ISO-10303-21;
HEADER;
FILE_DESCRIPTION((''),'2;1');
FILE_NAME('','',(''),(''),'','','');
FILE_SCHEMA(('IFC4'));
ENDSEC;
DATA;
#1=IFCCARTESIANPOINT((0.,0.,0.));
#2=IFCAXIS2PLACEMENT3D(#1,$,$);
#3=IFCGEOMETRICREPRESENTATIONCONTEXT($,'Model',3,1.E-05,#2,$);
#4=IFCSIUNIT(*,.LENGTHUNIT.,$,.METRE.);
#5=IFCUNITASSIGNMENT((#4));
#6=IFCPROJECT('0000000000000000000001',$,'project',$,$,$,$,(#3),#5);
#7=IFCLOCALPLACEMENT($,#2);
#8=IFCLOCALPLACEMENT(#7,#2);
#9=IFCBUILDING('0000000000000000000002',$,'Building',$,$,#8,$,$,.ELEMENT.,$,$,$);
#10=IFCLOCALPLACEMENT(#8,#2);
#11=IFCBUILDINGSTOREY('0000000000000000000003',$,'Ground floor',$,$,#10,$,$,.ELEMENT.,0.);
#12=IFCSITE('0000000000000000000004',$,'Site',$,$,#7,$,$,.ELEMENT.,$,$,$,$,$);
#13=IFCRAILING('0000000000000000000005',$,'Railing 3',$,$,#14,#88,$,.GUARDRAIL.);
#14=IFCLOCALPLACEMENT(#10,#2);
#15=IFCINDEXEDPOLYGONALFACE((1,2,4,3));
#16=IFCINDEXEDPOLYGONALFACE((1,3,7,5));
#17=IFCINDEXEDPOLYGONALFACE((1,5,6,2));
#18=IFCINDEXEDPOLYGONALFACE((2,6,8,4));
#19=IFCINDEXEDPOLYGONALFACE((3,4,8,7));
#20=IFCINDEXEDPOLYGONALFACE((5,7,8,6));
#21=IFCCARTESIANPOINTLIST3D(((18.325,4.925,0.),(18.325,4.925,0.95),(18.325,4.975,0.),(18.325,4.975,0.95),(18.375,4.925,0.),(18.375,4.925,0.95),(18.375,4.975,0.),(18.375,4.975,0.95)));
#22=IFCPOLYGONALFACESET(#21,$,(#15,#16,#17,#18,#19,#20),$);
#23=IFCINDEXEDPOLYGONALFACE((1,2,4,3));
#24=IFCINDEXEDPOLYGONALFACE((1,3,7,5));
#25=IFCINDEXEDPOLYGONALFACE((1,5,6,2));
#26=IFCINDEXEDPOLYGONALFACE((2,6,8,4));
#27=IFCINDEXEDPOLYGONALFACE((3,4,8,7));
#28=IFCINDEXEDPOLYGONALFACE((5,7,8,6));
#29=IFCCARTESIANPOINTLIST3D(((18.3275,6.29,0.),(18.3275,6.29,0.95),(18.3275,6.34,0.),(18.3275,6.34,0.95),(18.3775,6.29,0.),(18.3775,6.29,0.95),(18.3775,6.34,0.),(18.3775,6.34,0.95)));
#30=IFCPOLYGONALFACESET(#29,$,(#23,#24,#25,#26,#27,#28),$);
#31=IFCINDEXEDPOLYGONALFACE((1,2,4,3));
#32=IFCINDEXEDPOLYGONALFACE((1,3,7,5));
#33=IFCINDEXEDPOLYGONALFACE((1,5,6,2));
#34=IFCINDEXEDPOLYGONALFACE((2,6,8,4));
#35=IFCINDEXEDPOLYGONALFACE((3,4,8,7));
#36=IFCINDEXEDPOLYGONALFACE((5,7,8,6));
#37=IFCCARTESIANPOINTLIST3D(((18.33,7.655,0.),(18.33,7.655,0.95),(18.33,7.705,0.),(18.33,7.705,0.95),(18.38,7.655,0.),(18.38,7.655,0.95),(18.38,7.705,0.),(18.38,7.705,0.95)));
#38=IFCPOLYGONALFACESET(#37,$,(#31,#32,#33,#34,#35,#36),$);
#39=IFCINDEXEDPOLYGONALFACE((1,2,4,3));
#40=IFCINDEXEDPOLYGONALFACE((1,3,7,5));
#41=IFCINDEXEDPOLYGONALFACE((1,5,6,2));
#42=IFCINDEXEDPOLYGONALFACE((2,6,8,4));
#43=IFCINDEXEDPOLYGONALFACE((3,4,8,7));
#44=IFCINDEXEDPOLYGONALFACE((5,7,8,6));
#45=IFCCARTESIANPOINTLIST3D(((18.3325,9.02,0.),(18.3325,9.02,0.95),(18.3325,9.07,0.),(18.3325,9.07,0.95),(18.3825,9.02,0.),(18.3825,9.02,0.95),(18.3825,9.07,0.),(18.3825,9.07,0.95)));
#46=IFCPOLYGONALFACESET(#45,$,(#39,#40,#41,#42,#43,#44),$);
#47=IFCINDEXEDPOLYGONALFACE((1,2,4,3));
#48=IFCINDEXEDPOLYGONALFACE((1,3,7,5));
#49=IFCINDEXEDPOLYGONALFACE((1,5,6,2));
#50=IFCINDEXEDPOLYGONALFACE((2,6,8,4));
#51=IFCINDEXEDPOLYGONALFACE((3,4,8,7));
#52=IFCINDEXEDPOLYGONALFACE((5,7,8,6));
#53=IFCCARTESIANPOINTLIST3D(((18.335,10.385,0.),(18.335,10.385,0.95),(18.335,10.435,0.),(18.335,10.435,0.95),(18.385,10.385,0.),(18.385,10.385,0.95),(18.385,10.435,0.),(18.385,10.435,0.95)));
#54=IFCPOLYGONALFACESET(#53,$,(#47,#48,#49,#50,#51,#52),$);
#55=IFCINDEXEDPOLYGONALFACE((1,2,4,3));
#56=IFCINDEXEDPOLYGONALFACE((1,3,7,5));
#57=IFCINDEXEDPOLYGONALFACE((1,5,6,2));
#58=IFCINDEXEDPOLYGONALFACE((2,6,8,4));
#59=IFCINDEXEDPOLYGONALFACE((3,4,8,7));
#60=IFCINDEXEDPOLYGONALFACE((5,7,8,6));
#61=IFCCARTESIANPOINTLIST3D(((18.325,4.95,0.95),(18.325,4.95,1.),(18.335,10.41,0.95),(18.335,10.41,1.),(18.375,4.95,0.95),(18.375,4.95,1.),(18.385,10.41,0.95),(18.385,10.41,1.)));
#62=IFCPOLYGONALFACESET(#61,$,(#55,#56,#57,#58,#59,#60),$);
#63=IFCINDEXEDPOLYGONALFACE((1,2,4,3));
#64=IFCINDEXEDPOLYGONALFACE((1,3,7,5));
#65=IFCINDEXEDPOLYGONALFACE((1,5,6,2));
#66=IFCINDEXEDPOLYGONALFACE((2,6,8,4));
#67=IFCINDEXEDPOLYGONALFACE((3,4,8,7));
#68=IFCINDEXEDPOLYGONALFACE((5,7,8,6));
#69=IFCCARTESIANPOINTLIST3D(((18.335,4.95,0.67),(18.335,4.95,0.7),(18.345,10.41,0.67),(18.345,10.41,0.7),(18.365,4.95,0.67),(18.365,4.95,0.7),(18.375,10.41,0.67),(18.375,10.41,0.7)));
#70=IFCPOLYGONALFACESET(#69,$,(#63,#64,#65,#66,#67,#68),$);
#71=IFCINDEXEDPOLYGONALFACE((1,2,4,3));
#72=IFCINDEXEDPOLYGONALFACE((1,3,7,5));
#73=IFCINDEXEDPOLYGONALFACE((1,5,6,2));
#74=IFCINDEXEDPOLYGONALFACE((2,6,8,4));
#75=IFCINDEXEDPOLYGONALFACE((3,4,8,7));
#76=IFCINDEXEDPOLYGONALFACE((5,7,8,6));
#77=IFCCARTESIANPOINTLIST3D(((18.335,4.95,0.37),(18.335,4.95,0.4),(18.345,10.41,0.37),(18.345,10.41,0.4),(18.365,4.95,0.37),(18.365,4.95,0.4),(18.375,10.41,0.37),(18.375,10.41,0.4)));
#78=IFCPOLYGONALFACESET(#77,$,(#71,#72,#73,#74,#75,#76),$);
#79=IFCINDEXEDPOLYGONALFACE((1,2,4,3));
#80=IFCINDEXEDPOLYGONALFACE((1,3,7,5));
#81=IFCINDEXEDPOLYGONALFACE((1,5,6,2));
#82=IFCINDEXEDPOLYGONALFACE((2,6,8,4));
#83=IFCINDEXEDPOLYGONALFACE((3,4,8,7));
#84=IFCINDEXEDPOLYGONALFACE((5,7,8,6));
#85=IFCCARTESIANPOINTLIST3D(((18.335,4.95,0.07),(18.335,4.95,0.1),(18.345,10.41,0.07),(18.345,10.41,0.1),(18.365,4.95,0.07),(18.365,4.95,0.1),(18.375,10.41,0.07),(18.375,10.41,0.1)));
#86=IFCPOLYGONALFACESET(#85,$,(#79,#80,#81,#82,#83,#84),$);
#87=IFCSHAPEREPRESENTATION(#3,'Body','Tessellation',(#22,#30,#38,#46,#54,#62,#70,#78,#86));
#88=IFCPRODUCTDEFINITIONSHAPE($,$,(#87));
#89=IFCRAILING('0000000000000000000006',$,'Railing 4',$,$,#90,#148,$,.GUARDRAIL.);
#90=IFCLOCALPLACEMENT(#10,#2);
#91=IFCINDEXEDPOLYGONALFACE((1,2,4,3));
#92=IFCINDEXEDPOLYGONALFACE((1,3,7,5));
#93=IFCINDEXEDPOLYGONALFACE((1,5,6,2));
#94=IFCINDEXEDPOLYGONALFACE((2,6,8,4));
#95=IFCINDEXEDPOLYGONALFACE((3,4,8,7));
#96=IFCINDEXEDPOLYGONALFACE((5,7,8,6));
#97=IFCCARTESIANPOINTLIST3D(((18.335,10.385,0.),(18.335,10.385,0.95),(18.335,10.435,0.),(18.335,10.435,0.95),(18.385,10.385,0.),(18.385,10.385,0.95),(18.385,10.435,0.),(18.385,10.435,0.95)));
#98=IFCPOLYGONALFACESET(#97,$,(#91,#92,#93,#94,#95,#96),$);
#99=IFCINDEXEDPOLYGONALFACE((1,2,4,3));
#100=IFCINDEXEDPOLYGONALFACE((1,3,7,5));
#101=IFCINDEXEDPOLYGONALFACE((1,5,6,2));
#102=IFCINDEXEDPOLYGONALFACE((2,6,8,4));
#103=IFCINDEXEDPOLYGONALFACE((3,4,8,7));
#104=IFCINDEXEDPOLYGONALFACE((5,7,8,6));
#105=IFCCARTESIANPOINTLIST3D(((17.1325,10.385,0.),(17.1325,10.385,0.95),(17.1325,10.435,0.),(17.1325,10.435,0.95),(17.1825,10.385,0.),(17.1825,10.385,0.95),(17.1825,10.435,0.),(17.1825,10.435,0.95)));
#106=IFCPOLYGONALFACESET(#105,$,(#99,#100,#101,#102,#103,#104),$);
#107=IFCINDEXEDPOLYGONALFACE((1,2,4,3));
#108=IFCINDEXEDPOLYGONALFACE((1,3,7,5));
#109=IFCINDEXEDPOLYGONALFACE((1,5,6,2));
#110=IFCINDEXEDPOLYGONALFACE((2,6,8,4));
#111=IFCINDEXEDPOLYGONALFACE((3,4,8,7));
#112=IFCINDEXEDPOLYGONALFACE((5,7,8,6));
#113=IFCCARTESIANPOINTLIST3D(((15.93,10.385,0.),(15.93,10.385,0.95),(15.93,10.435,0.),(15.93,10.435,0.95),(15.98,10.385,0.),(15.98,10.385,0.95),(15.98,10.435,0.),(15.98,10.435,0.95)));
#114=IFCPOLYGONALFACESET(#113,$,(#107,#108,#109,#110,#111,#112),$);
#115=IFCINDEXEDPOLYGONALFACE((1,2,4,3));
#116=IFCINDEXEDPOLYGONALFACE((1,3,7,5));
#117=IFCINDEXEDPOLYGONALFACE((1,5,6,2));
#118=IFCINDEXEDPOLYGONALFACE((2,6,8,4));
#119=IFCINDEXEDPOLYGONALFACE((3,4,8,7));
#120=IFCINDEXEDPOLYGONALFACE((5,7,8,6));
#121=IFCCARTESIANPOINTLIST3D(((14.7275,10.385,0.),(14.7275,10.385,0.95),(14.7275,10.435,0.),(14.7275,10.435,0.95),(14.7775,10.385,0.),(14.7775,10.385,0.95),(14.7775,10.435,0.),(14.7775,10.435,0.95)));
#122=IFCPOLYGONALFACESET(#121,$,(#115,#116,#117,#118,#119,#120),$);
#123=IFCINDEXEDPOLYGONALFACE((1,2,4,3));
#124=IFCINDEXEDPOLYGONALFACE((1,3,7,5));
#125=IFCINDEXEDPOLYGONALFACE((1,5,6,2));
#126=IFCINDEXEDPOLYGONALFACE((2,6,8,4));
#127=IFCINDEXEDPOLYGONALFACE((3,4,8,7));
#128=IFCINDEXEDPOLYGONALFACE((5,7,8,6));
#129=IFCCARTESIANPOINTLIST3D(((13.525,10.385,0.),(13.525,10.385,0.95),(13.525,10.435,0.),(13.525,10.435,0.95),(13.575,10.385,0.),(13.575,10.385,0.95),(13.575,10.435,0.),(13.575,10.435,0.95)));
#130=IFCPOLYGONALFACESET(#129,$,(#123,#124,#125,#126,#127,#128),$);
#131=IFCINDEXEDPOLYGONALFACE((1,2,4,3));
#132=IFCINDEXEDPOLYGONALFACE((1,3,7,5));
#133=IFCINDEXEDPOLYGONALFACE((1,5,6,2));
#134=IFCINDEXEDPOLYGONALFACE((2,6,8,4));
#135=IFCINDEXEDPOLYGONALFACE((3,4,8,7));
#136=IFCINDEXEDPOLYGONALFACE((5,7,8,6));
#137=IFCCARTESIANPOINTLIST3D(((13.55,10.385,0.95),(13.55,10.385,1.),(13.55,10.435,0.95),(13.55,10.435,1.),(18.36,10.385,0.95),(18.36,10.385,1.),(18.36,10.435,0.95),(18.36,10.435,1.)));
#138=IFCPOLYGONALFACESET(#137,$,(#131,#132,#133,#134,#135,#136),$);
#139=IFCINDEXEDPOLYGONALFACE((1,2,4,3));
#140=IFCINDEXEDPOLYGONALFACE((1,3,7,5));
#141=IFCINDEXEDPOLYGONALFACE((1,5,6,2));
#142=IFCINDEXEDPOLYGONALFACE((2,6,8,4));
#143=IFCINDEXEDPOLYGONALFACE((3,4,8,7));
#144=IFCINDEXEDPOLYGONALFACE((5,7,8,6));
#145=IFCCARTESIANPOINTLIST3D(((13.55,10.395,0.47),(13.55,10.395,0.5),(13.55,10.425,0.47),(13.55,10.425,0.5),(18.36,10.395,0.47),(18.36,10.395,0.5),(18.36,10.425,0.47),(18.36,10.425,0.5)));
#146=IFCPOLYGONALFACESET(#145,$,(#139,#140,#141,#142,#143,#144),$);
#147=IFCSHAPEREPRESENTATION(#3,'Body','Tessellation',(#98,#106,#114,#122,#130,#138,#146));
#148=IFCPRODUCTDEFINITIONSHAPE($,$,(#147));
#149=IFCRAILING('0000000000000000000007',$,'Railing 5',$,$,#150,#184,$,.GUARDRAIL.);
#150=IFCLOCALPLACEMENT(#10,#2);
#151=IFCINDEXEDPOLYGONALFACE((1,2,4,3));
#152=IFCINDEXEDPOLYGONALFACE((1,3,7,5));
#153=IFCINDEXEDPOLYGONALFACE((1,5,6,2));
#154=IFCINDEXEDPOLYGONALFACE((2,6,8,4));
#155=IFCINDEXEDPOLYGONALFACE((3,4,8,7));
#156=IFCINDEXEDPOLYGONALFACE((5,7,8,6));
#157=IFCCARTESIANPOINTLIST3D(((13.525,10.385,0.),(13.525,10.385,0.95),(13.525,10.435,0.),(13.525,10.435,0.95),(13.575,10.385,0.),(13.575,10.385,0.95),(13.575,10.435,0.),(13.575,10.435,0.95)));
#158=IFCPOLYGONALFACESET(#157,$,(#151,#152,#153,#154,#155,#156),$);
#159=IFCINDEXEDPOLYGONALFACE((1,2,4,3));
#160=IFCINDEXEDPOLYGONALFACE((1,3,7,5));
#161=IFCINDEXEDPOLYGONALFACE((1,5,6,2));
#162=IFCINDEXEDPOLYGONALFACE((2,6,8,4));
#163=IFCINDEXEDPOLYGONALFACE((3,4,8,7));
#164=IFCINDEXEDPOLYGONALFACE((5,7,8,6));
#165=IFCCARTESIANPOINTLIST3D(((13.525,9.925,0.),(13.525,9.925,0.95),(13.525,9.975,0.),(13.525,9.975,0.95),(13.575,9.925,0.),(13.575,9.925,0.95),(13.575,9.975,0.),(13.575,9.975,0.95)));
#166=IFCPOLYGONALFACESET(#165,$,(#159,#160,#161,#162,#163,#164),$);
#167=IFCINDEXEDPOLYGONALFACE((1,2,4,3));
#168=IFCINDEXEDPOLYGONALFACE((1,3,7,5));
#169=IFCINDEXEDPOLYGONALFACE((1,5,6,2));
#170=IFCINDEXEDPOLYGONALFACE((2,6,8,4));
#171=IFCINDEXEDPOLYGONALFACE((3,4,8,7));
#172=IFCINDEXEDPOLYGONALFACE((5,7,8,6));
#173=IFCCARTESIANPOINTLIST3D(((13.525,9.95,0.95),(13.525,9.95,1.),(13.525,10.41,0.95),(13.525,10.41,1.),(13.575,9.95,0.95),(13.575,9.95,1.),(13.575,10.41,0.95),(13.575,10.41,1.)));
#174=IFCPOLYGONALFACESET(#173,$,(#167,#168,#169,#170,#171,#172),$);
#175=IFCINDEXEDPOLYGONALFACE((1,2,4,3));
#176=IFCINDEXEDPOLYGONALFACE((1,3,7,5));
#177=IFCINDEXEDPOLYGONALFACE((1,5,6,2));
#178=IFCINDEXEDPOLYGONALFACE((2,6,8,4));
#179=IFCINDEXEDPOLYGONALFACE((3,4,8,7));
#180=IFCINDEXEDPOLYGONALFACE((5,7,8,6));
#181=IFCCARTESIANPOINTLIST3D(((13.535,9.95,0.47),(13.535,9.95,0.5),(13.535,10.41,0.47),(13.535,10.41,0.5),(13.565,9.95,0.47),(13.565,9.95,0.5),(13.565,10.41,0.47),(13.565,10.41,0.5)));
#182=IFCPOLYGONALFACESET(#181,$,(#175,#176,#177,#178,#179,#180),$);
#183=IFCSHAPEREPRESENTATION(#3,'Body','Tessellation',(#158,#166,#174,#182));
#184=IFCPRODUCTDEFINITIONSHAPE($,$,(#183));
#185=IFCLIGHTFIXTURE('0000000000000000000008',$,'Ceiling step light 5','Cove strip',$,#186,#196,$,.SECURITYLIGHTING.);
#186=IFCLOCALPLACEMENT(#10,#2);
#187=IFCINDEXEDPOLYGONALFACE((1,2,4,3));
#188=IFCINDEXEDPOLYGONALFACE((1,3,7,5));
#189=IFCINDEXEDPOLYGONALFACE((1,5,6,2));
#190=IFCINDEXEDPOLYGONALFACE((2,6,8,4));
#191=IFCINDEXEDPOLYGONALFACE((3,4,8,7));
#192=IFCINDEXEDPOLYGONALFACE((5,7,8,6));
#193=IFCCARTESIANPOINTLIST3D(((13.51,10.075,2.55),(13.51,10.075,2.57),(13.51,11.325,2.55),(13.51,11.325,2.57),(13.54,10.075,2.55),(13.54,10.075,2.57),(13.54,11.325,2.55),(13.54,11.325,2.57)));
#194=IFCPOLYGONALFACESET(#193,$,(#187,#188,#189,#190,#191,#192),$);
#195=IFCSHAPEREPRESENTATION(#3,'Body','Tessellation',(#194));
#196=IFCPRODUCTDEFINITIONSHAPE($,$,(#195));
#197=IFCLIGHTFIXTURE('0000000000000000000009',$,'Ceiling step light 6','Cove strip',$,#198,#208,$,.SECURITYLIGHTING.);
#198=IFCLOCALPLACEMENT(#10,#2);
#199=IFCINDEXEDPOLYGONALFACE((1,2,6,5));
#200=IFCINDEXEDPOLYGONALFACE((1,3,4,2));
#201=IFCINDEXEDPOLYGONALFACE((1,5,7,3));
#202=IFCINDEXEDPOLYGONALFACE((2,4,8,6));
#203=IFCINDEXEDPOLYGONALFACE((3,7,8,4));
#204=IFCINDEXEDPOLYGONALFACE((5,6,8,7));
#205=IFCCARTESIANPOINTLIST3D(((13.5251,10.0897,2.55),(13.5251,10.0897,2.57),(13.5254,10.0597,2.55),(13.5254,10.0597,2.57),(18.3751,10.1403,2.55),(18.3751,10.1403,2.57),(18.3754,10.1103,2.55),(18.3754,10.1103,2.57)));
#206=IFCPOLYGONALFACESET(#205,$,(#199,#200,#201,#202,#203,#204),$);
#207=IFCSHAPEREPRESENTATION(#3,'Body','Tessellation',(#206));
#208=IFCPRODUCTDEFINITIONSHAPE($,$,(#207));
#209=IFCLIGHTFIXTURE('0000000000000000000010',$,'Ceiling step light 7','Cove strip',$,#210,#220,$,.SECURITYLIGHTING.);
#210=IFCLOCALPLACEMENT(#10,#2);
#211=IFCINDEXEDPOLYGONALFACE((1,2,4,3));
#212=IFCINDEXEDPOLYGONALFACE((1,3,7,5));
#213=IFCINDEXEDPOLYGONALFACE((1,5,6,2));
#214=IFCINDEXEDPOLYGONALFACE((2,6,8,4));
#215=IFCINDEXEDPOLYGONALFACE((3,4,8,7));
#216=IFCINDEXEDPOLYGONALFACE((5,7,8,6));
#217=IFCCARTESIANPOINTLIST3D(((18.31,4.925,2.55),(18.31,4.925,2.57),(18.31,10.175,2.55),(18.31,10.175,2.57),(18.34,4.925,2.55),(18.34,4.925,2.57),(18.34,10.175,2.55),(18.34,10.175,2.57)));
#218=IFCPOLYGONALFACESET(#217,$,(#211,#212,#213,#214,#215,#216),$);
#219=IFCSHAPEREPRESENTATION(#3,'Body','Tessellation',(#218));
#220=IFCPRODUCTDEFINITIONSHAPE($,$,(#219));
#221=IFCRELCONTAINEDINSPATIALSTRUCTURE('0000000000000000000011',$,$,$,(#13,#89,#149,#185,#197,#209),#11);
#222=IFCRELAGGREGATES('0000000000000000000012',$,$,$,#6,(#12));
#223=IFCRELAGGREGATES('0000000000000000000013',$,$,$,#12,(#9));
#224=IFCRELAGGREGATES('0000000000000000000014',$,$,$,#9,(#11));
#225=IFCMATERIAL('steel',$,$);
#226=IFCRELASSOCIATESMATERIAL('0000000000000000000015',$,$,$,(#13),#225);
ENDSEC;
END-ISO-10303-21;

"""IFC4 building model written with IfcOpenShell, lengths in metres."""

from ifc_helpers import new_model, si_unit, frame, frame_2d, origin, origin_2d, place, context, project, spatial, polyline, rectangle, outline, extrude, material, element, save


model = new_model("IFC4")

# Units and contexts
model_context = context("Model", 3, precision=1e-05, world=origin())
ifc_project = project(units=[si_unit("LENGTHUNIT", "METRE")], contexts=[model_context])

# Site, building, storey
site_placement = place(None, origin())
site = spatial("IfcSite", under=ifc_project, at=site_placement, Name="Site", CompositionType="ELEMENT")
building_placement = place(site_placement, origin())
building = spatial("IfcBuilding", under=site, at=building_placement, Name="Building", CompositionType="ELEMENT")
storey_placement = place(building_placement, origin())
storey = spatial("IfcBuildingStorey", under=building, at=storey_placement, Name="Ground floor", CompositionType="ELEMENT", Elevation=0.0)

# Railings
ifc_material = material(Name="steel")
railing_1_placement = place(storey_placement, frame((18.35, 4.95, 0.0), z_axis=(0.0, 0.0, 1.0), x_axis=(0.001831, 0.999998, 0.0)))
element("IfcRailing", 1, at=railing_1_placement, inside=storey, material=ifc_material, Name="Railing 3", PredefinedType="GUARDRAIL", context=model_context, shape_type="SweptSolid", body=[
    extrude(rectangle(XDim=0.05, YDim=0.05, at=origin_2d()), origin(), (0.0, 0.0, 1.0), 0.95),
    extrude(rectangle(XDim=0.05, YDim=0.05, at=frame_2d((1.365, 0.0))), origin(), (0.0, 0.0, 1.0), 0.95),
    extrude(rectangle(XDim=0.05, YDim=0.05, at=frame_2d((2.73, 0.0))), origin(), (0.0, 0.0, 1.0), 0.95),
    extrude(rectangle(XDim=0.05, YDim=0.05, at=frame_2d((4.095, 0.0))), origin(), (0.0, 0.0, 1.0), 0.95),
    extrude(rectangle(XDim=0.05, YDim=0.05, at=frame_2d((5.46, 0.0))), origin(), (0.0, 0.0, 1.0), 0.95),
    extrude(outline(polyline([(0.0, 0.95), (5.46, 0.95), (5.46, 1.0), (0.0, 1.0), (0.0, 0.95)])), frame((0.0, 0.025, 0.0), z_axis=(0.0, -1.0, 0.0), x_axis=(1.0, 0.0, 0.0)), (0.0, 0.0, 1.0), 0.05),
    extrude(outline(polyline([(0.0, 0.67), (5.46, 0.67), (5.46, 0.7), (0.0, 0.7), (0.0, 0.67)])), frame((0.0, 0.015, 0.0), z_axis=(0.0, -1.0, 0.0), x_axis=(1.0, 0.0, 0.0)), (0.0, 0.0, 1.0), 0.03),
    extrude(outline(polyline([(0.0, 0.37), (5.46, 0.37), (5.46, 0.4), (0.0, 0.4), (0.0, 0.37)])), frame((0.0, 0.015, 0.0), z_axis=(0.0, -1.0, 0.0), x_axis=(1.0, 0.0, 0.0)), (0.0, 0.0, 1.0), 0.03),
    extrude(outline(polyline([(0.0, 0.07), (5.46, 0.07), (5.46, 0.1), (0.0, 0.1), (0.0, 0.07)])), frame((0.0, 0.015, 0.0), z_axis=(0.0, -1.0, 0.0), x_axis=(1.0, 0.0, 0.0)), (0.0, 0.0, 1.0), 0.03),
])
railing_2_placement = place(storey_placement, frame((18.36, 10.41, 0.0), z_axis=(0.0, 0.0, 1.0), x_axis=(-1.0, 0.0, 0.0)))
element("IfcRailing", 2, at=railing_2_placement, inside=storey, Name="Railing 4", PredefinedType="GUARDRAIL", context=model_context, shape_type="SweptSolid", body=[
    extrude(rectangle(XDim=0.05, YDim=0.05, at=origin_2d()), origin(), (0.0, 0.0, 1.0), 0.95),
    extrude(rectangle(XDim=0.05, YDim=0.05, at=frame_2d((1.2025, 0.0))), origin(), (0.0, 0.0, 1.0), 0.95),
    extrude(rectangle(XDim=0.05, YDim=0.05, at=frame_2d((2.405, 0.0))), origin(), (0.0, 0.0, 1.0), 0.95),
    extrude(rectangle(XDim=0.05, YDim=0.05, at=frame_2d((3.6075, 0.0))), origin(), (0.0, 0.0, 1.0), 0.95),
    extrude(rectangle(XDim=0.05, YDim=0.05, at=frame_2d((4.81, 0.0))), origin(), (0.0, 0.0, 1.0), 0.95),
    extrude(outline(polyline([(0.0, 0.95), (4.81, 0.95), (4.81, 1.0), (0.0, 1.0), (0.0, 0.95)])), frame((0.0, 0.025, 0.0), z_axis=(0.0, -1.0, 0.0), x_axis=(1.0, 0.0, 0.0)), (0.0, 0.0, 1.0), 0.05),
    extrude(outline(polyline([(0.0, 0.47), (4.81, 0.47), (4.81, 0.5), (0.0, 0.5), (0.0, 0.47)])), frame((0.0, 0.015, 0.0), z_axis=(0.0, -1.0, 0.0), x_axis=(1.0, 0.0, 0.0)), (0.0, 0.0, 1.0), 0.03),
])
railing_3_placement = place(storey_placement, frame((13.55, 10.41, 0.0), z_axis=(0.0, 0.0, 1.0), x_axis=(0.0, -1.0, 0.0)))
element("IfcRailing", 3, at=railing_3_placement, inside=storey, Name="Railing 5", PredefinedType="GUARDRAIL", context=model_context, shape_type="SweptSolid", body=[
    extrude(rectangle(XDim=0.05, YDim=0.05, at=origin_2d()), origin(), (0.0, 0.0, 1.0), 0.95),
    extrude(rectangle(XDim=0.05, YDim=0.05, at=frame_2d((0.46, 0.0))), origin(), (0.0, 0.0, 1.0), 0.95),
    extrude(outline(polyline([(0.0, 0.95), (0.46, 0.95), (0.46, 1.0), (0.0, 1.0), (0.0, 0.95)])), frame((0.0, 0.025, 0.0), z_axis=(0.0, -1.0, 0.0), x_axis=(1.0, 0.0, 0.0)), (0.0, 0.0, 1.0), 0.05),
    extrude(outline(polyline([(0.0, 0.47), (0.46, 0.47), (0.46, 0.5), (0.0, 0.5), (0.0, 0.47)])), frame((0.0, 0.015, 0.0), z_axis=(0.0, -1.0, 0.0), x_axis=(1.0, 0.0, 0.0)), (0.0, 0.0, 1.0), 0.03),
])

# Light fixtures
light_fixture_1_placement = place(storey_placement, frame((13.525, 10.7, 2.55), z_axis=(0.0, 0.0, 1.0), x_axis=(0.0, -1.0, 0.0)))
element("IfcLightFixture", 4, at=light_fixture_1_placement, inside=storey, Name="Ceiling step light 5", Description="Cove strip", PredefinedType="SECURITYLIGHTING", context=model_context, shape_type="SweptSolid", body=[
    extrude(rectangle(XDim=1.25, YDim=0.03, at=origin_2d()), origin(), (0.0, 0.0, 1.0), 0.02),
])
light_fixture_2_placement = place(storey_placement, frame((15.9503, 10.1, 2.55), z_axis=(0.0, 0.0, 1.0), x_axis=(0.999946, 0.010416, 0.0)))
element("IfcLightFixture", 5, at=light_fixture_2_placement, inside=storey, Name="Ceiling step light 6", Description="Cove strip", PredefinedType="SECURITYLIGHTING", context=model_context, shape_type="SweptSolid", body=[
    extrude(rectangle(XDim=4.8503, YDim=0.03, at=origin_2d()), origin(), (0.0, 0.0, 1.0), 0.02),
])
light_fixture_3_placement = place(storey_placement, frame((18.325, 7.55, 2.55), z_axis=(0.0, 0.0, 1.0), x_axis=(0.0, -1.0, 0.0)))
element("IfcLightFixture", 6, at=light_fixture_3_placement, inside=storey, Name="Ceiling step light 7", Description="Cove strip", PredefinedType="SECURITYLIGHTING", context=model_context, shape_type="SweptSolid", body=[
    extrude(rectangle(XDim=5.25, YDim=0.03, at=origin_2d()), origin(), (0.0, 0.0, 1.0), 0.02),
])

save(model, "model.ifc")
